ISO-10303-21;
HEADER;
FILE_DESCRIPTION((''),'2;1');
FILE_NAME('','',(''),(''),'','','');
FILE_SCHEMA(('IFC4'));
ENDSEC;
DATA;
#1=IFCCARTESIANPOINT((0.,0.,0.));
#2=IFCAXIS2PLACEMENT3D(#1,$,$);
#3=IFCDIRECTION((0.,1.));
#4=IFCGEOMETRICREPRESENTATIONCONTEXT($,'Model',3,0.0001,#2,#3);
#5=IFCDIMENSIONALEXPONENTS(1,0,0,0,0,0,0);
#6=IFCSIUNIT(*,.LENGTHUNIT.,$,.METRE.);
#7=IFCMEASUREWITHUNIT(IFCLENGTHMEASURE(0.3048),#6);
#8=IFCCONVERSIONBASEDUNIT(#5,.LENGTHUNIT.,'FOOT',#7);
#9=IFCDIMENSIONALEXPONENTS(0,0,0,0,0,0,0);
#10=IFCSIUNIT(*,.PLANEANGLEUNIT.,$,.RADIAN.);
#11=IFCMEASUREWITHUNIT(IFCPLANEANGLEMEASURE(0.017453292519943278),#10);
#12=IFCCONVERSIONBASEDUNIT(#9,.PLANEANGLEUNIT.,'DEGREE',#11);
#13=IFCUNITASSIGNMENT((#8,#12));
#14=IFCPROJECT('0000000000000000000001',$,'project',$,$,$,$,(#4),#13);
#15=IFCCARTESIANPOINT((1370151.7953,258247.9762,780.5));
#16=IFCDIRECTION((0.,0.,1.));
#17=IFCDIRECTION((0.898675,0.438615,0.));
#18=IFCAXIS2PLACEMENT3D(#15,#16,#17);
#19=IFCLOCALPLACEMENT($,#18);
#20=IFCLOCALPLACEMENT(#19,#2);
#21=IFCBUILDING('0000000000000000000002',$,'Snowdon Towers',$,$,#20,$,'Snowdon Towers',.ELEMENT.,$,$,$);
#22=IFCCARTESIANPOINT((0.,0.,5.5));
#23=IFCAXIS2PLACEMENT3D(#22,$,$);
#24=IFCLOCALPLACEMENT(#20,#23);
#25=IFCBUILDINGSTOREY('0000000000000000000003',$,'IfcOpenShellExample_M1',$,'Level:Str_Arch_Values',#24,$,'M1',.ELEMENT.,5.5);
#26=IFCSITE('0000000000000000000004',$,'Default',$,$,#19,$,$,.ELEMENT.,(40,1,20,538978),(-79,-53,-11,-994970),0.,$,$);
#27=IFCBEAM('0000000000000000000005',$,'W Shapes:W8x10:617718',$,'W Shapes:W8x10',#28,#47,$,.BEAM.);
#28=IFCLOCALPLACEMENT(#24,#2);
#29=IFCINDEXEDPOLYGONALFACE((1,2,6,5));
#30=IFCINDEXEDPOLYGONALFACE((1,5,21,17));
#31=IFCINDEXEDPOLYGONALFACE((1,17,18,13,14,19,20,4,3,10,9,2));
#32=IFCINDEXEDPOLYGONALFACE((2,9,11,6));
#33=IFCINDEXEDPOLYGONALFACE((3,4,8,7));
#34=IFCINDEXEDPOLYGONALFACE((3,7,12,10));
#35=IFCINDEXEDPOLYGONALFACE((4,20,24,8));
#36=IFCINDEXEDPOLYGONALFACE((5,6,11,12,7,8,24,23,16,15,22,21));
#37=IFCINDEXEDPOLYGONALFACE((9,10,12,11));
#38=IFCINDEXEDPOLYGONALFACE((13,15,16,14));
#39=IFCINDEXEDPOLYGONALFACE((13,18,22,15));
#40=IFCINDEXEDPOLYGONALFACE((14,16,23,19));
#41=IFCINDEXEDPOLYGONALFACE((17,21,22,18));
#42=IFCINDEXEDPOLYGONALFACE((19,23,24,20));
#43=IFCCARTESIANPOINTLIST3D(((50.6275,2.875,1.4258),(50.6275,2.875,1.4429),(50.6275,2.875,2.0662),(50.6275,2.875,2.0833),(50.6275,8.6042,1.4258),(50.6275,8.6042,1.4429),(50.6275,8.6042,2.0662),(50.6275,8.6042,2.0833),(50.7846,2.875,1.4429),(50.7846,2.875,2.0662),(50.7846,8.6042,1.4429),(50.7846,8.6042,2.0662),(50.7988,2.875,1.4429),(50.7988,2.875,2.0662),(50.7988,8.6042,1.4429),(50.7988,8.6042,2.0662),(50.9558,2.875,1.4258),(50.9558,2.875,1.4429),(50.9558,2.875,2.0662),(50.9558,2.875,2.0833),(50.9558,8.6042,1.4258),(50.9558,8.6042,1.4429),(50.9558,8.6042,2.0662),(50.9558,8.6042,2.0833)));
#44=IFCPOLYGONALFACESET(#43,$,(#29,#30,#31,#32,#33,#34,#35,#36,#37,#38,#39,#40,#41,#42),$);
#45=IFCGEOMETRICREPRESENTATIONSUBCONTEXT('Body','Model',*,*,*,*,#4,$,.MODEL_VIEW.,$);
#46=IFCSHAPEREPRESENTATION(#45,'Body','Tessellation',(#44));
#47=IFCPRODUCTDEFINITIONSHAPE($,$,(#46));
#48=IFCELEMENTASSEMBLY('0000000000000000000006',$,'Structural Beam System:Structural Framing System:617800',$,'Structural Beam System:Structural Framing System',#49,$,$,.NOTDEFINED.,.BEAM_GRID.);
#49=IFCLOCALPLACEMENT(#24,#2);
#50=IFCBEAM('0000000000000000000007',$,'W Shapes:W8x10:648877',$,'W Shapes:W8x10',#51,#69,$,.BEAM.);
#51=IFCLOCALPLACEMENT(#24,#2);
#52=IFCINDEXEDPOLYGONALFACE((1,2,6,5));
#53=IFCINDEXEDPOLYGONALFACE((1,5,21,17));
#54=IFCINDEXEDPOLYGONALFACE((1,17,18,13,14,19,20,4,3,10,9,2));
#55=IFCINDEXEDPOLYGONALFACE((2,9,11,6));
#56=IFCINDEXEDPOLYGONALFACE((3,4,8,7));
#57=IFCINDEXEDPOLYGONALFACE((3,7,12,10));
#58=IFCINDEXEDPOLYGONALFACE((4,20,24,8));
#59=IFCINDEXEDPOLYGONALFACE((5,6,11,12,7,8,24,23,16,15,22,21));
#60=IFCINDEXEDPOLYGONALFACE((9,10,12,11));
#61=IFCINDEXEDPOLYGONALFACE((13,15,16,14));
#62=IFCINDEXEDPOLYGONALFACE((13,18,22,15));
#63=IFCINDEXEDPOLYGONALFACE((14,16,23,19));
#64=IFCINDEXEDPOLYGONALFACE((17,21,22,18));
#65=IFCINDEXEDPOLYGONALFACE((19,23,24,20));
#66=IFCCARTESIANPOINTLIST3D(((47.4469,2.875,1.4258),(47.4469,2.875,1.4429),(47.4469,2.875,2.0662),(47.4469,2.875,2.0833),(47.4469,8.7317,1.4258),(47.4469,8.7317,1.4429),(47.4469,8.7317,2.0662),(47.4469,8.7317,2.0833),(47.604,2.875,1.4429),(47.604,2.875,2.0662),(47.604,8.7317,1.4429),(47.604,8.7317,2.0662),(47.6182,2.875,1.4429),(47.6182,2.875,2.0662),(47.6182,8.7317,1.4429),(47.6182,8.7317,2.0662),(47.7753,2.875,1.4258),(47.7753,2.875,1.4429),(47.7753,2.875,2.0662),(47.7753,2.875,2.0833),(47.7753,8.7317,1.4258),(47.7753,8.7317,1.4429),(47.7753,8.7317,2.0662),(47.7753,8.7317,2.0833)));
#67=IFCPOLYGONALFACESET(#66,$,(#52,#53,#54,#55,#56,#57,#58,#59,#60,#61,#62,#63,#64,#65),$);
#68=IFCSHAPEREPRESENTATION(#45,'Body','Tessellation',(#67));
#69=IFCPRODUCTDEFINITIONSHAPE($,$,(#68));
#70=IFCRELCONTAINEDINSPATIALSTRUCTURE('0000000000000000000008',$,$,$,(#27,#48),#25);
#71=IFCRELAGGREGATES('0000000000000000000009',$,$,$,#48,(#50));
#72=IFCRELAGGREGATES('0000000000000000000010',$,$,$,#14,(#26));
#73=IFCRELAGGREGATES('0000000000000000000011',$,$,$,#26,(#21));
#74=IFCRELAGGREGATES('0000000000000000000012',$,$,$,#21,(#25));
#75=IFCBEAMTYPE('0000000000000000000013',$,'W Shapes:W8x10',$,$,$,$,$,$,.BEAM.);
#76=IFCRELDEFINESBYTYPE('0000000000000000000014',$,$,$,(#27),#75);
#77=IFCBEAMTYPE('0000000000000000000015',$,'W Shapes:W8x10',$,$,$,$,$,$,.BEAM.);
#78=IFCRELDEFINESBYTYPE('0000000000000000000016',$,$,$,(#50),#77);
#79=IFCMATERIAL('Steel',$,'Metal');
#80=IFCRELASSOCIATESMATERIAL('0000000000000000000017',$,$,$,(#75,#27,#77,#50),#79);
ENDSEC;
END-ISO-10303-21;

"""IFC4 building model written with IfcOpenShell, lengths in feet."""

from ifc_helpers import new_model, entity, si_unit, converted_unit, direction, frame, origin, place, context, subcontext, project, spatial, indexed_curve, outline, extrude, source, transform, mapped, material, type_object, type_shapes, element, aggregate, save


model = new_model("IFC4")

# Units and contexts
model_context = context("Model", 3, precision=0.0001, world=origin(), true_north=direction((0.0, 1.0)))
body_context = subcontext(model_context, "Body", "Model", "MODEL_VIEW")
ifc_project = project(units=[converted_unit("LENGTHUNIT", "FOOT", entity("IfcLengthMeasure", 0.3048), si_unit("LENGTHUNIT", "METRE"), dimensions=[1, 0, 0, 0, 0, 0, 0]), converted_unit("PLANEANGLEUNIT", "DEGREE", entity("IfcPlaneAngleMeasure", 0.017453292519943278), si_unit("PLANEANGLEUNIT", "RADIAN"), dimensions=[0, 0, 0, 0, 0, 0, 0])], contexts=[model_context])

# Site, building, storey
site_placement = place(None, frame((1370151.7953, 258247.9762, 780.5), z_axis=(0.0, 0.0, 1.0), x_axis=(0.898675, 0.438615, 0.0)))
site = spatial("IfcSite", under=ifc_project, at=site_placement, Name="Default", CompositionType="ELEMENT", RefLatitude=(40, 1, 20, 538978), RefLongitude=(-79, -53, -11, -994970), RefElevation=0.0)
building_placement = place(site_placement, origin())
building = spatial("IfcBuilding", under=site, at=building_placement, Name="Snowdon Towers", LongName="Snowdon Towers", CompositionType="ELEMENT")
storey_placement = place(building_placement, frame((0.0, 0.0, 5.5)))
storey = spatial("IfcBuildingStorey", under=building, at=storey_placement, Name="IfcOpenShellExample_M1", ObjectType="Level:Str_Arch_Values", LongName="M1", CompositionType="ELEMENT", Elevation=5.5)

# Shared definitions
ifc_material = material(Name="Steel", Category="Metal")

# Beam
beam_type_1 = type_object("IfcBeamType", Name="W Shapes:W8x10", PredefinedType="BEAM", material=ifc_material)
shared_shape_1 = source(origin(), body_context, "Body", "SweptSolid", [
    extrude(outline(indexed_curve([(-0.1642, -0.3117), (-0.1642, -0.3288), (0.1642, -0.3288), (0.1642, -0.3117), (0.0071, -0.3117), (0.0071, 0.3117), (0.1642, 0.3117), (0.1642, 0.3287), (-0.1642, 0.3287), (-0.1642, 0.3117), (-0.0071, 0.3117), (-0.0071, -0.3117), (-0.1642, -0.3117)], self_intersect=False)), frame((-2.9167, 0.0, 0.0), z_axis=(-1.0, 0.0, 0.0), x_axis=(0.0, -1.0, 0.0)), (0.0, 0.0, -1.0), 5.7292),
])
type_shapes(beam_type_1, [shared_shape_1])
beam_1_placement = place(storey_placement, frame((50.7917, 5.6875, 1.7546), z_axis=(0.0, 0.0, 1.0), x_axis=(0.0, -1.0, 0.0)))
element("IfcBeam", 1, at=beam_1_placement, inside=storey, type_object=beam_type_1, material=ifc_material, Name="W Shapes:W8x10:617718", ObjectType="W Shapes:W8x10", PredefinedType="BEAM", context=body_context, shape_type="MappedRepresentation", body=[
    mapped(shared_shape_1, transform((0.0, 0.0, 0.0), scale=1.0)),
])

# Element assembly, beam
assembly_1_placement = place(storey_placement, origin())
assembly_1 = element("IfcElementAssembly", 2, at=assembly_1_placement, inside=storey, Name="Structural Beam System:Structural Framing System:617800", ObjectType="Structural Beam System:Structural Framing System", AssemblyPlace="NOTDEFINED", PredefinedType="BEAM_GRID")
beam_type_2 = type_object("IfcBeamType", Name="W Shapes:W8x10", PredefinedType="BEAM", material=ifc_material)
shared_shape_2 = source(origin(), body_context, "Body", "SweptSolid", [
    extrude(outline(indexed_curve([(-0.1642, -0.3117), (-0.1642, -0.3288), (0.1642, -0.3288), (0.1642, -0.3117), (0.0071, -0.3117), (0.0071, 0.3117), (0.1642, 0.3117), (0.1642, 0.3287), (-0.1642, 0.3287), (-0.1642, 0.3117), (-0.0071, 0.3117), (-0.0071, -0.3117), (-0.1642, -0.3117)], self_intersect=False)), frame((-3.0962, 0.0, 0.0), z_axis=(-1.0, 0.0, 0.0), x_axis=(0.0, -1.0, 0.0)), (0.0, 0.0, -1.0), 5.8567),
])
type_shapes(beam_type_2, [shared_shape_2])
beam_2_placement = place(assembly_1_placement, frame((47.6111, 5.6354, 1.7546), z_axis=(0.0, 0.0, 1.0), x_axis=(0.0, -1.0, 0.0)))
beam_2 = element("IfcBeam", 3, at=beam_2_placement, type_object=beam_type_2, material=ifc_material, Name="W Shapes:W8x10:648877", ObjectType="W Shapes:W8x10", PredefinedType="BEAM", context=body_context, shape_type="MappedRepresentation", body=[
    mapped(shared_shape_2, transform((0.0, 0.0, 0.0), scale=1.0)),
])
aggregate(assembly_1, [beam_2])

save(model, "model.ifc")
